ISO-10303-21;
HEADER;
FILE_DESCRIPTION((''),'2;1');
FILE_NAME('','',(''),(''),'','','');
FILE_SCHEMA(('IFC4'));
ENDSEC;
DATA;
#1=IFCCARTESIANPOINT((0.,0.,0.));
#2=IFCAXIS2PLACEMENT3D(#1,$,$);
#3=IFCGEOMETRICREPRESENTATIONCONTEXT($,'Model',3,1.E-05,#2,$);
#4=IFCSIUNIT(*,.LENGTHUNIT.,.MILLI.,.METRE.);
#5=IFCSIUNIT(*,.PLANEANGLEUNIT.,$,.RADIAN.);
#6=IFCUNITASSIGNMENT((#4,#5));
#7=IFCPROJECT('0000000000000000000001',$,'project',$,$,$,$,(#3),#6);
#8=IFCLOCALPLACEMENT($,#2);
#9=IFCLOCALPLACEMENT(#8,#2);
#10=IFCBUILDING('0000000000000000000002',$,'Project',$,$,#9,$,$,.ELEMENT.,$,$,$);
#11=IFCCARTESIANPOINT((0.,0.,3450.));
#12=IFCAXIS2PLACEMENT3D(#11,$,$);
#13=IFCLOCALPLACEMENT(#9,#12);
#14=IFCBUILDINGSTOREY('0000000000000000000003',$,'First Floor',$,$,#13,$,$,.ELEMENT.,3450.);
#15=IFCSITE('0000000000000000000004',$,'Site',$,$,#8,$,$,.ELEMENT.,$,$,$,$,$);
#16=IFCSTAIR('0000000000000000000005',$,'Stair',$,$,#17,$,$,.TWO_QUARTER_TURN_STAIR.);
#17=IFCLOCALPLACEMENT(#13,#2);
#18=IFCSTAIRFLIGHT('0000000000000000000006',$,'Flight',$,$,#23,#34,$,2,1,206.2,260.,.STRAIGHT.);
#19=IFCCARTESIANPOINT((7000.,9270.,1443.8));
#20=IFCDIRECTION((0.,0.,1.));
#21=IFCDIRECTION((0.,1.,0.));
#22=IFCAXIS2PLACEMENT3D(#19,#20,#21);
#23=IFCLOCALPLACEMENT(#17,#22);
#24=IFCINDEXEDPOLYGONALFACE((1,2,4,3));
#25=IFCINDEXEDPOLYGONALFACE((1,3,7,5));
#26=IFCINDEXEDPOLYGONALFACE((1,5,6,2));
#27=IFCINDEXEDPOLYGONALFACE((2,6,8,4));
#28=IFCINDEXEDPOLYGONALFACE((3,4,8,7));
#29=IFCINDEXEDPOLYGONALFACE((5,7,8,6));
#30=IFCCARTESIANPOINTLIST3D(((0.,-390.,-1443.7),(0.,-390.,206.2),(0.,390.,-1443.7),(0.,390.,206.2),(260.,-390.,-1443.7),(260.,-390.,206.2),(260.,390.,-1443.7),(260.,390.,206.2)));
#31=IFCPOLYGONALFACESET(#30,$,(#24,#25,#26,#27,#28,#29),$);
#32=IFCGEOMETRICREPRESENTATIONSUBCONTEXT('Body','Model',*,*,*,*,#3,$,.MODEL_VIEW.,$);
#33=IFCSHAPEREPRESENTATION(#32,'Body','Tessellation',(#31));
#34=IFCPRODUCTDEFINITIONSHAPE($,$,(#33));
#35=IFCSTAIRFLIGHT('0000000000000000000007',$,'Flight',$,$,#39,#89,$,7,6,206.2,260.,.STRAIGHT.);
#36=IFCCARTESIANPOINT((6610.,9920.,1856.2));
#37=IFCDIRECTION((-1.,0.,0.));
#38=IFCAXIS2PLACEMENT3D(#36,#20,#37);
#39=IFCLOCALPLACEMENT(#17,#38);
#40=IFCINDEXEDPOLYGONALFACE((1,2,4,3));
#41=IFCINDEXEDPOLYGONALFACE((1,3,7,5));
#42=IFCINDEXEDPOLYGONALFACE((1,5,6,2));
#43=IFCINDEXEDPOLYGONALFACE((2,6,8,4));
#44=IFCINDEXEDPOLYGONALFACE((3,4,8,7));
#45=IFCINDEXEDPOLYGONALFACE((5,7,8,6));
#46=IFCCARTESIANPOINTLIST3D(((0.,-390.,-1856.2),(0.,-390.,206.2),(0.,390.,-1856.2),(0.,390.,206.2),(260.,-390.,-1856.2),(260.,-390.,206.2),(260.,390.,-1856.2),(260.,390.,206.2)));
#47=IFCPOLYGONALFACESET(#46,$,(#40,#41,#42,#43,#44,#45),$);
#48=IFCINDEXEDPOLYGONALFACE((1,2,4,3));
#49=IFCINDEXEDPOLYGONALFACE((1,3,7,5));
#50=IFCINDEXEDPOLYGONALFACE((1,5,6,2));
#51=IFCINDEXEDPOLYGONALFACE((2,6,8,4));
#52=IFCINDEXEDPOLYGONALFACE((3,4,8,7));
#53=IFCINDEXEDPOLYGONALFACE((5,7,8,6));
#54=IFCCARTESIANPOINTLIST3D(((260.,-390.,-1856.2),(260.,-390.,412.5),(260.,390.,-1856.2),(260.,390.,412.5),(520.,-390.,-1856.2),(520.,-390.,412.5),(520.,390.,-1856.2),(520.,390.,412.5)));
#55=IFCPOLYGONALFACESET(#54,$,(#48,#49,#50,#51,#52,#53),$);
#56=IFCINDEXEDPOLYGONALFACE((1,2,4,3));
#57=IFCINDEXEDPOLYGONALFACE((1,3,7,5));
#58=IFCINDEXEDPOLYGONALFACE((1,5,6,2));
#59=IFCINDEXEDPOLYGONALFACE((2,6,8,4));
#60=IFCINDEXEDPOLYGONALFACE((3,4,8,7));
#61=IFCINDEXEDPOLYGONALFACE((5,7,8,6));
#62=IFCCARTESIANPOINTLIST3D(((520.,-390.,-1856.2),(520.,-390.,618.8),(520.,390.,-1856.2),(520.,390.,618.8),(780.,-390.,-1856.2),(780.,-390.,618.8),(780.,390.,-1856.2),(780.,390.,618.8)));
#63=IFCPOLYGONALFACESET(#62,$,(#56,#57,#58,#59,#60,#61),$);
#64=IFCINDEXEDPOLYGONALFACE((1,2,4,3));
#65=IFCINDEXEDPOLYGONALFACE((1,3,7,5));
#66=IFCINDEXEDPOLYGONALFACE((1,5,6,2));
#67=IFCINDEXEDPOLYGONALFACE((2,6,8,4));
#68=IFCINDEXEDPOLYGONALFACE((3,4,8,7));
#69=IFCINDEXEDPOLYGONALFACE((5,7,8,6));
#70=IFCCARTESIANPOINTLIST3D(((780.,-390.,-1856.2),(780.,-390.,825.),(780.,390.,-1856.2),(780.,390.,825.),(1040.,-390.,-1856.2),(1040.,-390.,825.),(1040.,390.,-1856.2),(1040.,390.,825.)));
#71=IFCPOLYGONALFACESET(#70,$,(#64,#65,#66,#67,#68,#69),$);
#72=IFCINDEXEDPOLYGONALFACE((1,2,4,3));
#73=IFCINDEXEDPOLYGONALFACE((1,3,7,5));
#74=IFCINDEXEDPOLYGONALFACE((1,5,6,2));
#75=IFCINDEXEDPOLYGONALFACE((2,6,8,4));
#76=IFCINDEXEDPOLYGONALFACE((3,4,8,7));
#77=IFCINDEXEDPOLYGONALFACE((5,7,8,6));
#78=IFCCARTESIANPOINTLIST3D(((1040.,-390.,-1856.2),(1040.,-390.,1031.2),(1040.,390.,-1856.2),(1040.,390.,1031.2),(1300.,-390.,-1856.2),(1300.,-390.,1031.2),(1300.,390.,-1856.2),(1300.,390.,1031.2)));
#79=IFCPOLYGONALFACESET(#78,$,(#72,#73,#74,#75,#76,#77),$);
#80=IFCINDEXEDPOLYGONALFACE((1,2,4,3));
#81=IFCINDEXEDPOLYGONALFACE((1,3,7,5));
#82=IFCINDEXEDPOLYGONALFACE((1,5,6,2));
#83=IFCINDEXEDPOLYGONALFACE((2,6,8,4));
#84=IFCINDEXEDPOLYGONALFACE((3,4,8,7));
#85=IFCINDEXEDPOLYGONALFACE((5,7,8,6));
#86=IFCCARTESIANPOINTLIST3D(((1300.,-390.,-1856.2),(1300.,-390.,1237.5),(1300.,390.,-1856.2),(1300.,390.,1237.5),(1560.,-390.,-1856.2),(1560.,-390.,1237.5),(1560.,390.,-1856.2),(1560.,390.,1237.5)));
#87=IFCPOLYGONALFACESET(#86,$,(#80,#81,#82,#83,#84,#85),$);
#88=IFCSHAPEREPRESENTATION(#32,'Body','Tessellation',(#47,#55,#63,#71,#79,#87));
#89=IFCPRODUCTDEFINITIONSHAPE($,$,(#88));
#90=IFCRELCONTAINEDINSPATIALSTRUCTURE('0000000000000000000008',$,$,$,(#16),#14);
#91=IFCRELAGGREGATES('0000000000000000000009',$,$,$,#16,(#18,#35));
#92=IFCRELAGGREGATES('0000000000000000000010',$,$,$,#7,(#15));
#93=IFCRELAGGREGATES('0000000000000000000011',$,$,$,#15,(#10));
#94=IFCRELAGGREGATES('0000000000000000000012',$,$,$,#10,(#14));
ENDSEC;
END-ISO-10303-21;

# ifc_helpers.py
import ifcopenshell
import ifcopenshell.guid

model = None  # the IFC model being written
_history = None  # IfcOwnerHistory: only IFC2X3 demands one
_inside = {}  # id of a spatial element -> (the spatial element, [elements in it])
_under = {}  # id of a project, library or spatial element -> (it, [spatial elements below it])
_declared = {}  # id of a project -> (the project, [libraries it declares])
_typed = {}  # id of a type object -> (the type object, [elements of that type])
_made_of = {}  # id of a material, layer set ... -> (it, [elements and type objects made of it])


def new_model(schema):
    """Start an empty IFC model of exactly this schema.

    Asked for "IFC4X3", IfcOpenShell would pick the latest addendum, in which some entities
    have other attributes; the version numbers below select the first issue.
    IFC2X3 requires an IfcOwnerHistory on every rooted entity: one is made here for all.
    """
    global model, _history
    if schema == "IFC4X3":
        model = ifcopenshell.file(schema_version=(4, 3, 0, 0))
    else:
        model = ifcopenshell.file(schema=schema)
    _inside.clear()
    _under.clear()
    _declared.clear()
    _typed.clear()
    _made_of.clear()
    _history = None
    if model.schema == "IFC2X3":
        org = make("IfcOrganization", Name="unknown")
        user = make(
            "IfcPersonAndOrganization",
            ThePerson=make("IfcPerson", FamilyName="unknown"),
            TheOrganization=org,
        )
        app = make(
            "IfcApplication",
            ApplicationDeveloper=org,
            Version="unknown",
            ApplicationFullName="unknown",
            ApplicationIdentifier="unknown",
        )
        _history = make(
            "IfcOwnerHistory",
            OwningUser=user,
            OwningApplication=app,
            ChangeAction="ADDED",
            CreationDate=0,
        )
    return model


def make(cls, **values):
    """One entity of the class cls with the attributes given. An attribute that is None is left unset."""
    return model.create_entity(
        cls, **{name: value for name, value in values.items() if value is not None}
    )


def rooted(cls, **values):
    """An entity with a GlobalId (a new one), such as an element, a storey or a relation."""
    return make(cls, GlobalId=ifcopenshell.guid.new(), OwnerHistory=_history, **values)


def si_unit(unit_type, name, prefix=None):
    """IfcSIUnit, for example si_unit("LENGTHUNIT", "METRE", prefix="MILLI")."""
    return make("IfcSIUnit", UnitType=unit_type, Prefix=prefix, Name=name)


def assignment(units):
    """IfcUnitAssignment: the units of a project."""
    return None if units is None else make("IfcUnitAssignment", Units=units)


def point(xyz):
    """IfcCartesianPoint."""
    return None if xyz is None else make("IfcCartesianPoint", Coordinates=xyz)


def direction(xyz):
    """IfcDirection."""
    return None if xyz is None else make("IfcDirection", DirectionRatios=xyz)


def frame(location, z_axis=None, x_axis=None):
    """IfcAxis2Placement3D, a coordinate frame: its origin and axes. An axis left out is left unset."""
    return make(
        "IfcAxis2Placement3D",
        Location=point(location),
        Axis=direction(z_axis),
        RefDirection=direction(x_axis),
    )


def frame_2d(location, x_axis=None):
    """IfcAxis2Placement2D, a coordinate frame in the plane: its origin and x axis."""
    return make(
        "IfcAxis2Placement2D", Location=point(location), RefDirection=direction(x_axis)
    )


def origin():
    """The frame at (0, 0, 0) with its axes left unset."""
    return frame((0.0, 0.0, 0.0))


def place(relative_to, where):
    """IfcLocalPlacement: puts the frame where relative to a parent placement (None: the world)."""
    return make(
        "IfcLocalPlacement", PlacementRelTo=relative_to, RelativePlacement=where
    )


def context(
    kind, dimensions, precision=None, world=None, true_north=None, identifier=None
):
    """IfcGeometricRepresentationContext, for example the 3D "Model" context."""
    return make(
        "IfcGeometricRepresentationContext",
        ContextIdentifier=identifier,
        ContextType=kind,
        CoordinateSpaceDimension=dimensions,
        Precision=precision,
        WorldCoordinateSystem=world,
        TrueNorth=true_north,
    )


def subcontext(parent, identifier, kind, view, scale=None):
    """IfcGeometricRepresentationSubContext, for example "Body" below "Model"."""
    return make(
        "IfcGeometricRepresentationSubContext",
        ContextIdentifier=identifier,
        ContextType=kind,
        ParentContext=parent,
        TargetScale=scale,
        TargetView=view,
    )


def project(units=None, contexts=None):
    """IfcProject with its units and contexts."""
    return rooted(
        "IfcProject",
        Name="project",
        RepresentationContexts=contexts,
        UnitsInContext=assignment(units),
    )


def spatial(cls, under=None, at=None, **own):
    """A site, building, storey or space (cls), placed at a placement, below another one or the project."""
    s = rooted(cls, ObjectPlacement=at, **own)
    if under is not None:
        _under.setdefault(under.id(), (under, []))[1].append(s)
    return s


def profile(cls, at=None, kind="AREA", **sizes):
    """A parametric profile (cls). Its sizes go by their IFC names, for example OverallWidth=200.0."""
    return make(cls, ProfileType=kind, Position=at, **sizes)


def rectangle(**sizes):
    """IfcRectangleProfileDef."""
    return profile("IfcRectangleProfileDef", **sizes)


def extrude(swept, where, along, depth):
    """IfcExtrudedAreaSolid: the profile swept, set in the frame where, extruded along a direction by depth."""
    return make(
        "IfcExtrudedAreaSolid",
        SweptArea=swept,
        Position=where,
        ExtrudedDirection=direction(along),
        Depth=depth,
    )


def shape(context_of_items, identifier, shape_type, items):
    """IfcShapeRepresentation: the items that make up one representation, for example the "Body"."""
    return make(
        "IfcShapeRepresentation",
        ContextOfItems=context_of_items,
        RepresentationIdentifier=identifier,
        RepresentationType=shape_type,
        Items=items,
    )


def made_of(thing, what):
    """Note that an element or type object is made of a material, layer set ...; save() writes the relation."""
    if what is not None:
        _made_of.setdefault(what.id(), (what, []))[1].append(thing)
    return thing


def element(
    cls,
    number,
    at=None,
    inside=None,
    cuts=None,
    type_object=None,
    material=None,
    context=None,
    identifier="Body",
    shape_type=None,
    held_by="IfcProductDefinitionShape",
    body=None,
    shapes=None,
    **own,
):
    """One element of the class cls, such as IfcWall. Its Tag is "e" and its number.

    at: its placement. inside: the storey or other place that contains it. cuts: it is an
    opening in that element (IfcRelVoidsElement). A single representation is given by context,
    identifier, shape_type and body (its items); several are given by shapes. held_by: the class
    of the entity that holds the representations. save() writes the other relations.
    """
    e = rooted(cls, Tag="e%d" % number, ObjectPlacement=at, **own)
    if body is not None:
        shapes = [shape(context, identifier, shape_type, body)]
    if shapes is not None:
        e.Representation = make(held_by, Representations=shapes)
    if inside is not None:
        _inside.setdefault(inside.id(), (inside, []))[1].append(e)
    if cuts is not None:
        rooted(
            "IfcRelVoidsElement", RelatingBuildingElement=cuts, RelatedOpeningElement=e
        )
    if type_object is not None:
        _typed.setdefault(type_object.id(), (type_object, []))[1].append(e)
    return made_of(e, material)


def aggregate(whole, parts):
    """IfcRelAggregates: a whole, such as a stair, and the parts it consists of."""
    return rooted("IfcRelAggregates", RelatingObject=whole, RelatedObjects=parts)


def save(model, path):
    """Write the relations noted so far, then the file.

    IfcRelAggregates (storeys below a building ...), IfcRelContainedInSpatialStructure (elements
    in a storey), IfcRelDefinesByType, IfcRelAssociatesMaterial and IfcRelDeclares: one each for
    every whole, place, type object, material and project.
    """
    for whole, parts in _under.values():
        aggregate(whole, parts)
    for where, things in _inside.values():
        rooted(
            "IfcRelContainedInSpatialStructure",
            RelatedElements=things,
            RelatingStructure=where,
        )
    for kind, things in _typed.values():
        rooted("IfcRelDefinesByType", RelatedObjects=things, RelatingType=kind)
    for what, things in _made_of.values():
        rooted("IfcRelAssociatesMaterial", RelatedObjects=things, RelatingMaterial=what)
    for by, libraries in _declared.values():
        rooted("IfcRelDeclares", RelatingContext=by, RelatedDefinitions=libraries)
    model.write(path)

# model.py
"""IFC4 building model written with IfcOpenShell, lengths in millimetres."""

from ifc_helpers import new_model, si_unit, frame, frame_2d, origin, place, context, subcontext, project, spatial, rectangle, extrude, element, aggregate, save


model = new_model("IFC4")

# Units and contexts
model_context = context("Model", 3, precision=1e-05, world=origin())
body_context = subcontext(model_context, "Body", "Model", "MODEL_VIEW")
ifc_project = project(units=[si_unit("LENGTHUNIT", "METRE", prefix="MILLI"), si_unit("PLANEANGLEUNIT", "RADIAN")], contexts=[model_context])

# Site, building, storey
site_placement = place(None, origin())
site = spatial("IfcSite", under=ifc_project, at=site_placement, Name="Site", CompositionType="ELEMENT")
building_placement = place(site_placement, origin())
building = spatial("IfcBuilding", under=site, at=building_placement, Name="Project", CompositionType="ELEMENT")
storey_placement = place(building_placement, frame((0.0, 0.0, 3450.0)))
storey = spatial("IfcBuildingStorey", under=building, at=storey_placement, Name="First Floor", CompositionType="ELEMENT", Elevation=3450.0)

# Stair, stair flights
stair_placement = place(storey_placement, origin())
stair = element("IfcStair", 1, at=stair_placement, inside=storey, Name="Stair", PredefinedType="TWO_QUARTER_TURN_STAIR")
stair_flight_1_placement = place(stair_placement, frame((7000.0, 9270.0, 1443.8), z_axis=(0.0, 0.0, 1.0), x_axis=(0.0, 1.0, 0.0)))
stair_flight_1 = element("IfcStairFlight", 2, at=stair_flight_1_placement, Name="Flight", NumberOfRisers=2, NumberOfTreads=1, PredefinedType="STRAIGHT", RiserHeight=206.2, TreadLength=260.0, context=body_context, shape_type="SweptSolid", body=[
    extrude(rectangle(XDim=260.0, YDim=780.0, at=frame_2d((130.0, 0.0))), frame((0.0, 0.0, -1443.8)), (0.0, 0.0, 1.0), 1650.0),
])
stair_flight_2_placement = place(stair_placement, frame((6610.0, 9920.0, 1856.2), z_axis=(0.0, 0.0, 1.0), x_axis=(-1.0, 0.0, 0.0)))
stair_flight_2 = element("IfcStairFlight", 3, at=stair_flight_2_placement, Name="Flight", NumberOfRisers=7, NumberOfTreads=6, PredefinedType="STRAIGHT", RiserHeight=206.2, TreadLength=260.0, context=body_context, shape_type="SweptSolid", body=[
    extrude(rectangle(XDim=260.0, YDim=780.0, at=frame_2d((130.0, 0.0))), frame((0.0, 0.0, -1856.2)), (0.0, 0.0, 1.0), 2062.5),
    extrude(rectangle(XDim=260.0, YDim=780.0, at=frame_2d((390.0, 0.0))), frame((0.0, 0.0, -1856.2)), (0.0, 0.0, 1.0), 2268.8),
    extrude(rectangle(XDim=260.0, YDim=780.0, at=frame_2d((650.0, 0.0))), frame((0.0, 0.0, -1856.2)), (0.0, 0.0, 1.0), 2475.0),
    extrude(rectangle(XDim=260.0, YDim=780.0, at=frame_2d((910.0, 0.0))), frame((0.0, 0.0, -1856.2)), (0.0, 0.0, 1.0), 2681.2),
    extrude(rectangle(XDim=260.0, YDim=780.0, at=frame_2d((1170.0, 0.0))), frame((0.0, 0.0, -1856.2)), (0.0, 0.0, 1.0), 2887.5),
    extrude(rectangle(XDim=260.0, YDim=780.0, at=frame_2d((1430.0, 0.0))), frame((0.0, 0.0, -1856.2)), (0.0, 0.0, 1.0), 3093.8),
])
aggregate(stair, [stair_flight_1, stair_flight_2])

save(model, "model.ifc")
